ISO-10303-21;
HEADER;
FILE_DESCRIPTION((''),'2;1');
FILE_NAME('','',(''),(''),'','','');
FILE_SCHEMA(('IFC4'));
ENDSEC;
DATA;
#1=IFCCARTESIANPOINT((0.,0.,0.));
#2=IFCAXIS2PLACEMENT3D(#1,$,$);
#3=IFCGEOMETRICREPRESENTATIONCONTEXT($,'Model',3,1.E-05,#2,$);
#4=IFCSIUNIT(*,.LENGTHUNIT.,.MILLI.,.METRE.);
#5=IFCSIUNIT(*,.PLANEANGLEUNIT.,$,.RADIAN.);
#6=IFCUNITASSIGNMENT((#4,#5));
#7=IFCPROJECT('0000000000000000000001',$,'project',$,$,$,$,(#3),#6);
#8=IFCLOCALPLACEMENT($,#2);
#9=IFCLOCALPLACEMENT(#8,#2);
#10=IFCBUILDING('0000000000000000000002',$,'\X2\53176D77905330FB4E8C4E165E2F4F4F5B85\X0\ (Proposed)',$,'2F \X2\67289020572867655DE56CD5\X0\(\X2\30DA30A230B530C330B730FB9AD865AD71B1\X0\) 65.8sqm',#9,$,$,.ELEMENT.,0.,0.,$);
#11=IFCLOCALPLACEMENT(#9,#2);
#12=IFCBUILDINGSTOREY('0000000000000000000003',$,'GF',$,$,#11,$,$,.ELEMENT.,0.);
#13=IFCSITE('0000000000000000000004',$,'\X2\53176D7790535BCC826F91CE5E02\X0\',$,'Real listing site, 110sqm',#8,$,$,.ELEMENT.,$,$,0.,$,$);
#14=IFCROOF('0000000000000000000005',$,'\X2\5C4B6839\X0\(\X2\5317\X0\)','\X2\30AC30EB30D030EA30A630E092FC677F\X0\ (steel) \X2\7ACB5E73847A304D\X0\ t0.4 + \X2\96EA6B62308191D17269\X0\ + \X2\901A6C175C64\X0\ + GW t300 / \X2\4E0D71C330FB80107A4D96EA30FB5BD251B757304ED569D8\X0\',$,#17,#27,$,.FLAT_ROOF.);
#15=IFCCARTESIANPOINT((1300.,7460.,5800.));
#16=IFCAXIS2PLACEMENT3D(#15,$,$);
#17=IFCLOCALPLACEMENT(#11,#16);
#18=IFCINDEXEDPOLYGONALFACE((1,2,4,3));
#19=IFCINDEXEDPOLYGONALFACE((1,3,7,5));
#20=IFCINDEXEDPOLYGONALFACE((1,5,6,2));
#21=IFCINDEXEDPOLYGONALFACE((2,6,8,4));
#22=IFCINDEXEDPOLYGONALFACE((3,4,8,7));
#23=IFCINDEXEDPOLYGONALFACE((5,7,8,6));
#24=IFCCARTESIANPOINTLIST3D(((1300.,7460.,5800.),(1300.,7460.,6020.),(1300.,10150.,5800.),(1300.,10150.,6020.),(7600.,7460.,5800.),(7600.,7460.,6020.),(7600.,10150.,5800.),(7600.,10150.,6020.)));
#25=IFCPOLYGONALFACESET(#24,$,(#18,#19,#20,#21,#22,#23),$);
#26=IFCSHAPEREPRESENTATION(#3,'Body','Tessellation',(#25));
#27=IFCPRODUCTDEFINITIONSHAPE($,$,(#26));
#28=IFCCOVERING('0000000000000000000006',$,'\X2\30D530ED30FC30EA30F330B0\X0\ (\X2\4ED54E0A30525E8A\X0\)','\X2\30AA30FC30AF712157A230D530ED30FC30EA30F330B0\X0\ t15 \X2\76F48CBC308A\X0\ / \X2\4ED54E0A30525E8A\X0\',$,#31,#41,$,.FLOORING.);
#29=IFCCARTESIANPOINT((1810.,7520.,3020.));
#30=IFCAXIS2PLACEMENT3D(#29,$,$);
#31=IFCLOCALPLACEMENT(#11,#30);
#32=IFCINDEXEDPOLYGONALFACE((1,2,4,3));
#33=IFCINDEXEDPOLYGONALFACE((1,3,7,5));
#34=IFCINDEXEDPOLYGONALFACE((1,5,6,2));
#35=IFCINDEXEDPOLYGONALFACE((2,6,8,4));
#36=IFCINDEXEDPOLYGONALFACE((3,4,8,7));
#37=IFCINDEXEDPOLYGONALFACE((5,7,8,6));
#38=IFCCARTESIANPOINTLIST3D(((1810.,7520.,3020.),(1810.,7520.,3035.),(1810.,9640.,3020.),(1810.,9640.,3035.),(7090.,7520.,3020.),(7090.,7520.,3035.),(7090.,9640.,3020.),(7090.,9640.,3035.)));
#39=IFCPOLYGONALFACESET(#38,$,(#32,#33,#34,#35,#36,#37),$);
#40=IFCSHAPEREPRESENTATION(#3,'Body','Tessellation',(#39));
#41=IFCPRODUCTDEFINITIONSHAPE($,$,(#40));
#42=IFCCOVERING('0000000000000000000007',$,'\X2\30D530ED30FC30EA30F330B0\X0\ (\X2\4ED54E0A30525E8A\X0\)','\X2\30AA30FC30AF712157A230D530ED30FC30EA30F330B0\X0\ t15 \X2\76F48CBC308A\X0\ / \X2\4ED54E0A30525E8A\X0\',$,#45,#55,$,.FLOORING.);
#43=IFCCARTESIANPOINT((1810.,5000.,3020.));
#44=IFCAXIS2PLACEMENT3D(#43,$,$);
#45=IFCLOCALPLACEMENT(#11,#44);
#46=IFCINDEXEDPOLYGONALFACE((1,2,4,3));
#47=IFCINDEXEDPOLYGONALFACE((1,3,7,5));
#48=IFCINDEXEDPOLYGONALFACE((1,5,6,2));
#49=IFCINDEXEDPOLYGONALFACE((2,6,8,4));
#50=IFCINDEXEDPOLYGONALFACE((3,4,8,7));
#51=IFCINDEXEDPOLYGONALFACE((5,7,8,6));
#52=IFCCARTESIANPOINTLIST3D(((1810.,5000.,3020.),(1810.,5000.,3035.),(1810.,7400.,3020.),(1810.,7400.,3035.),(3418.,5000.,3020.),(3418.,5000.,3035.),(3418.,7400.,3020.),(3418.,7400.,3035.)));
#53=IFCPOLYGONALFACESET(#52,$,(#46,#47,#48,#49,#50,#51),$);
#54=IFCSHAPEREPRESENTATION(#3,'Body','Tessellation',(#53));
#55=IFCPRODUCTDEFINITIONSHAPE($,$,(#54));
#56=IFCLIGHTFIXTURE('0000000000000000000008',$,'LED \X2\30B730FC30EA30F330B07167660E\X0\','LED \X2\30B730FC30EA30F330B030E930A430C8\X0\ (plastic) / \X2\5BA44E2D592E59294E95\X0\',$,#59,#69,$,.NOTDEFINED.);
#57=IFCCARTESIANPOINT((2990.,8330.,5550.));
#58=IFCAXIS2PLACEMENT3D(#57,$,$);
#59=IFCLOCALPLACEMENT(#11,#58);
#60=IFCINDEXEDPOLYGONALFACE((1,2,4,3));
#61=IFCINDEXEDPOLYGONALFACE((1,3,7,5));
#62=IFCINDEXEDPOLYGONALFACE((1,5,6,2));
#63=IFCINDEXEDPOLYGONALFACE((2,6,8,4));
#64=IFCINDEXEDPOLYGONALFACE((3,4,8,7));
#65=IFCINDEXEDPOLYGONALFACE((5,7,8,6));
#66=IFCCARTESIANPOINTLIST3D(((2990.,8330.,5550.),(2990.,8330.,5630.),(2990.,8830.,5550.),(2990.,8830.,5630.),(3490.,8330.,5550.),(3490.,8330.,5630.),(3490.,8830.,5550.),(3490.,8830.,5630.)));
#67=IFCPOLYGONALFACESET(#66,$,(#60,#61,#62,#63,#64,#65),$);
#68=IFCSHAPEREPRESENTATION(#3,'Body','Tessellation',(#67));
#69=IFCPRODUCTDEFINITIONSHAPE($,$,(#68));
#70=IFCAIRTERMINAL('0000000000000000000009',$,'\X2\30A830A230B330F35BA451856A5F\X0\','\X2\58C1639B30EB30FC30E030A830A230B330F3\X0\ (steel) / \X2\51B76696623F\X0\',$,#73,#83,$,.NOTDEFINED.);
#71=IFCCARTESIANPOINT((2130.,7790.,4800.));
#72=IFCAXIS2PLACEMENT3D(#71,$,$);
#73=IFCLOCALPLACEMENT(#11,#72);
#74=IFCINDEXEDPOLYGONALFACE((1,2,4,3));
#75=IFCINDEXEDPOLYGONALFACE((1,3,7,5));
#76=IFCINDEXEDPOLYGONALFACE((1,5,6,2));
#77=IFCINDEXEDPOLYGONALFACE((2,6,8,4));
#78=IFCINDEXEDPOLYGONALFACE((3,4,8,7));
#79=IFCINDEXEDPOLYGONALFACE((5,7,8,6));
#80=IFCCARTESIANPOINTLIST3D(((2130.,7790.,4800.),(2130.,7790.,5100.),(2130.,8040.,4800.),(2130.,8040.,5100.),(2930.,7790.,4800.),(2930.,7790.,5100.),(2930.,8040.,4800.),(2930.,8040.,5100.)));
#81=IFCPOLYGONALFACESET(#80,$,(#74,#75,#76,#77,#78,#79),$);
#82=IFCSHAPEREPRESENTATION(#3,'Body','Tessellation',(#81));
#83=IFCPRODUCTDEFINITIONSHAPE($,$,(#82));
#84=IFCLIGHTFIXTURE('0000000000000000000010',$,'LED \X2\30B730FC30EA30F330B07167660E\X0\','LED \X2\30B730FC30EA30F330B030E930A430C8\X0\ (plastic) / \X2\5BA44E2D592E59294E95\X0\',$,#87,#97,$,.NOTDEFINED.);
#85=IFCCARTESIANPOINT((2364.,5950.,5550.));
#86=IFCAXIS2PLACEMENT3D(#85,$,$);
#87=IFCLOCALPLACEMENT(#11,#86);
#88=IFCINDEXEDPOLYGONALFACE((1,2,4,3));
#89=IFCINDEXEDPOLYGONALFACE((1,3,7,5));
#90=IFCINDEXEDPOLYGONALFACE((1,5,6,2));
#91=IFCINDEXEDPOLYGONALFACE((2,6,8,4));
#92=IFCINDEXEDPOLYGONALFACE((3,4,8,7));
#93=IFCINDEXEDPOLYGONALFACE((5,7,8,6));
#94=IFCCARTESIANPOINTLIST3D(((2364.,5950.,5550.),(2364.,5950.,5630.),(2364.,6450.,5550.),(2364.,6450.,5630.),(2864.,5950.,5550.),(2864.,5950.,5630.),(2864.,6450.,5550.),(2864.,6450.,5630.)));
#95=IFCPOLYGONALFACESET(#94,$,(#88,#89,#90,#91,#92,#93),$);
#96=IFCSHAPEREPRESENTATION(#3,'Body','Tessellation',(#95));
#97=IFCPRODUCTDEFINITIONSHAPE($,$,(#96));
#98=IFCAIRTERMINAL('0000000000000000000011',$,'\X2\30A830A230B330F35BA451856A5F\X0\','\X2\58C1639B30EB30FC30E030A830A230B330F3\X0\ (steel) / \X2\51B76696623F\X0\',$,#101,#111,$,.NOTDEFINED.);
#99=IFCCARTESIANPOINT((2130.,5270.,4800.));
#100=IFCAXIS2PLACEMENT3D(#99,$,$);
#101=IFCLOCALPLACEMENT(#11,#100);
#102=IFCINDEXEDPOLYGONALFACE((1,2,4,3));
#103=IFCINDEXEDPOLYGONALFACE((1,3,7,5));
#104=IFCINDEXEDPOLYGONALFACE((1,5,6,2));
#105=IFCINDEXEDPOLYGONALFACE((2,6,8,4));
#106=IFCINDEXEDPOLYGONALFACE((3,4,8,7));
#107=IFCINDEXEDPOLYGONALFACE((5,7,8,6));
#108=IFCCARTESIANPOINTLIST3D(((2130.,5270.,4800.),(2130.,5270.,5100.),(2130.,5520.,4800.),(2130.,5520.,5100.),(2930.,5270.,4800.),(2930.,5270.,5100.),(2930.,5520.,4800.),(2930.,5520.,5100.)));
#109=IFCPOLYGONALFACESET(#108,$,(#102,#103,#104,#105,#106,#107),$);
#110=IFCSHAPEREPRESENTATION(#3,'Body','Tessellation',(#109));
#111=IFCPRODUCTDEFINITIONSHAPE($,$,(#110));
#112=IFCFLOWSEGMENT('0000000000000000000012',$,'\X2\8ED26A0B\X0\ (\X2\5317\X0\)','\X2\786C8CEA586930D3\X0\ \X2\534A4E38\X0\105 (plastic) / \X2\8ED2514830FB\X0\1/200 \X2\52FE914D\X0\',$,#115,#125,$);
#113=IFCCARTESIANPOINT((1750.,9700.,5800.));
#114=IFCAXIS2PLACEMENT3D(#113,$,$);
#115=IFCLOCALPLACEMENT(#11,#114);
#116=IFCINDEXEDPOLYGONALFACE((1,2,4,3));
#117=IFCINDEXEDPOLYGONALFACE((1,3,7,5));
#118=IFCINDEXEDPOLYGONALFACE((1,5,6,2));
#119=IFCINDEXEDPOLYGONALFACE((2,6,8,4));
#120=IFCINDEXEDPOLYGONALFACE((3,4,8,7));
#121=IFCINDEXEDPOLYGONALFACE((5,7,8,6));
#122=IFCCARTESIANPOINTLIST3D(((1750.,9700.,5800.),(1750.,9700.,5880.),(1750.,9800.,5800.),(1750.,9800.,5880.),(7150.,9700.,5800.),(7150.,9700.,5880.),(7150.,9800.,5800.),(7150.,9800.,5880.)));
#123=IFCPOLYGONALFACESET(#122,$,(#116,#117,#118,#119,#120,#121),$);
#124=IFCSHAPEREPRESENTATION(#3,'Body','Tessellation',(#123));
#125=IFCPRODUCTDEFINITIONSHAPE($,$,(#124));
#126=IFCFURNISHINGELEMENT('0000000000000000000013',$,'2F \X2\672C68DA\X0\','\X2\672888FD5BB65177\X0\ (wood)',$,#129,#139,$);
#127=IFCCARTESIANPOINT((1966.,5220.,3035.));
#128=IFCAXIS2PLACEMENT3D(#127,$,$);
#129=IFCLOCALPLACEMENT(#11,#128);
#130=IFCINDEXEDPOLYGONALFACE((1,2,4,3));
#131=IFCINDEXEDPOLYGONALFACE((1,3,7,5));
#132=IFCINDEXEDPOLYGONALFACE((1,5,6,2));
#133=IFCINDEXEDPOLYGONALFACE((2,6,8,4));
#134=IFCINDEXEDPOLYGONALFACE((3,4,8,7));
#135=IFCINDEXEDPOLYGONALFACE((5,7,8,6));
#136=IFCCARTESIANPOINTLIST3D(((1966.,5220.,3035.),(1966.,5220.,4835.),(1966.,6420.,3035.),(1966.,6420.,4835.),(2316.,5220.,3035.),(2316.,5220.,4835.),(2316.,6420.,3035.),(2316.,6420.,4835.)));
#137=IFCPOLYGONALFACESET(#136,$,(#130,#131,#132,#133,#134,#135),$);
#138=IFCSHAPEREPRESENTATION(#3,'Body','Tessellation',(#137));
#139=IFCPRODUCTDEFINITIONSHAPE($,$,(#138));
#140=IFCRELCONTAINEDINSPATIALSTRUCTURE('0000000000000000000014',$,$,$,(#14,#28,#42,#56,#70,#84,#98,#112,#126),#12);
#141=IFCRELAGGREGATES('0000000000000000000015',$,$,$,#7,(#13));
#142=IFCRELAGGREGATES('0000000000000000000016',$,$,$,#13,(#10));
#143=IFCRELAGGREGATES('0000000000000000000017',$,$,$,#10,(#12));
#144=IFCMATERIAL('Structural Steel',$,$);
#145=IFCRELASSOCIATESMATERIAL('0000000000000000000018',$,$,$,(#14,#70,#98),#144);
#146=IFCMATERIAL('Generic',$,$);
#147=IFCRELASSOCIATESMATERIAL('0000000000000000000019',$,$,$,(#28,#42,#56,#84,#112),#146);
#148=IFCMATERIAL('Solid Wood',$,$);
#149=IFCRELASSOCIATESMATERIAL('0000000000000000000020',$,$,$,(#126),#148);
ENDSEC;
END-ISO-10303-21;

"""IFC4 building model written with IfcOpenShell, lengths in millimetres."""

from ifc_helpers import new_model, si_unit, frame, frame_2d, origin, place, context, project, spatial, rectangle, extrude, material, element, save


model = new_model("IFC4")

# Units and contexts
model_context = context("Model", 3, precision=1e-05, world=origin())
ifc_project = project(units=[si_unit("LENGTHUNIT", "METRE", prefix="MILLI"), si_unit("PLANEANGLEUNIT", "RADIAN")], contexts=[model_context])

# Site, building, storey
site_placement = place(None, origin())
site = spatial("IfcSite", under=ifc_project, at=site_placement, Name="北海道富良野市", ObjectType="Real listing site, 110sqm", CompositionType="ELEMENT", RefElevation=0.0)
building_placement = place(site_placement, origin())
building = spatial("IfcBuilding", under=site, at=building_placement, Name="北海道・二世帯住宅 (Proposed)", ObjectType="2F 木造在来工法(ペアサッシ・高断熱) 65.8sqm", CompositionType="ELEMENT", ElevationOfRefHeight=0.0, ElevationOfTerrain=0.0)
storey_placement = place(building_placement, origin())
storey = spatial("IfcBuildingStorey", under=building, at=storey_placement, Name="GF", CompositionType="ELEMENT", Elevation=0.0)

# Shared definitions
ifc_material_1 = material(Name="Solid Wood")

# Roof
ifc_material_2 = material(Name="Structural Steel")
for number, where, name in (
    (1, (1300.0, 7460.0, 5800.0), "屋根(北)"),
):
    element("IfcRoof", number, at=place(storey_placement, frame(where)), inside=storey, material=ifc_material_2, Name=name, Description="ガルバリウム鋼板 (steel) 立平葺き t0.4 + 雪止め金物 + 通気層 + GW t300 / 不燃・耐積雪・寒冷地仕様", PredefinedType="FLAT_ROOF", context=model_context, shape_type="SweptSolid", body=[
        extrude(rectangle(XDim=6300.0, YDim=2690.0, at=frame_2d((3150.0, 1345.0))), frame((1300.0, 7460.0, 5800.0)), (0.0, 0.0, 1.0), 220.0),
    ])

# Coverings
ifc_material_3 = material(Name="Generic")
covering_1_placement = place(storey_placement, frame((1810.0, 7520.0, 3020.0)))
element("IfcCovering", 2, at=covering_1_placement, inside=storey, material=ifc_material_3, Name="フローリング (仕上げ床)", Description="オーク無垢フローリング t15 直貼り / 仕上げ床", PredefinedType="FLOORING", context=model_context, shape_type="SweptSolid", body=[
    extrude(rectangle(XDim=5280.0, YDim=2120.0, at=frame_2d((2640.0, 1060.0))), frame((1810.0, 7520.0, 3020.0)), (0.0, 0.0, 1.0), 15.0),
])
covering_2_placement = place(storey_placement, frame((1810.0, 5000.0, 3020.0)))
element("IfcCovering", 3, at=covering_2_placement, inside=storey, material=ifc_material_3, Name="フローリング (仕上げ床)", Description="オーク無垢フローリング t15 直貼り / 仕上げ床", PredefinedType="FLOORING", context=model_context, shape_type="SweptSolid", body=[
    extrude(rectangle(XDim=1608.0, YDim=2400.0, at=frame_2d((804.0, 1200.0))), frame((1810.0, 5000.0, 3020.0)), (0.0, 0.0, 1.0), 15.0),
])

# Light fixture
light_fixture_1_placement = place(storey_placement, frame((2990.0, 8330.0, 5550.0)))
element("IfcLightFixture", 4, at=light_fixture_1_placement, inside=storey, material=ifc_material_3, Name="LED シーリング照明", Description="LED シーリングライト (plastic) / 室中央天井", PredefinedType="NOTDEFINED", context=model_context, shape_type="SweptSolid", body=[
    extrude(rectangle(XDim=500.0, YDim=500.0, at=frame_2d((250.0, 250.0))), frame((2990.0, 8330.0, 5550.0)), (0.0, 0.0, 1.0), 80.0),
])

# Air terminal
air_terminal_1_placement = place(storey_placement, frame((2130.0, 7790.0, 4800.0)))
element("IfcAirTerminal", 5, at=air_terminal_1_placement, inside=storey, material=ifc_material_2, Name="エアコン室内機", Description="壁掛ルームエアコン (steel) / 冷暖房", PredefinedType="NOTDEFINED", context=model_context, shape_type="SweptSolid", body=[
    extrude(rectangle(XDim=800.0, YDim=250.0, at=frame_2d((400.0, 125.0))), frame((2130.0, 7790.0, 4800.0)), (0.0, 0.0, 1.0), 300.0),
])

# Light fixture
light_fixture_2_placement = place(storey_placement, frame((2364.0, 5950.0, 5550.0)))
element("IfcLightFixture", 6, at=light_fixture_2_placement, inside=storey, material=ifc_material_3, Name="LED シーリング照明", Description="LED シーリングライト (plastic) / 室中央天井", PredefinedType="NOTDEFINED", context=model_context, shape_type="SweptSolid", body=[
    extrude(rectangle(XDim=500.0, YDim=500.0, at=frame_2d((250.0, 250.0))), frame((2364.0, 5950.0, 5550.0)), (0.0, 0.0, 1.0), 80.0),
])

# Air terminal
air_terminal_2_placement = place(storey_placement, frame((2130.0, 5270.0, 4800.0)))
element("IfcAirTerminal", 7, at=air_terminal_2_placement, inside=storey, material=ifc_material_2, Name="エアコン室内機", Description="壁掛ルームエアコン (steel) / 冷暖房", PredefinedType="NOTDEFINED", context=model_context, shape_type="SweptSolid", body=[
    extrude(rectangle(XDim=800.0, YDim=250.0, at=frame_2d((400.0, 125.0))), frame((2130.0, 5270.0, 4800.0)), (0.0, 0.0, 1.0), 300.0),
])

# Flow segment
flow_segment_placement = place(storey_placement, frame((1750.0, 9700.0, 5800.0)))
element("IfcFlowSegment", 8, at=flow_segment_placement, inside=storey, material=ifc_material_3, Name="軒樋 (北)", Description="硬質塩ビ 半丸105 (plastic) / 軒先・1/200 勾配", context=model_context, shape_type="SweptSolid", body=[
    extrude(rectangle(XDim=5400.0, YDim=100.0, at=frame_2d((2700.0, 50.0))), frame((1750.0, 9700.0, 5800.0)), (0.0, 0.0, 1.0), 80.0),
])

# Furnishing element
furnishing_placement = place(storey_placement, frame((1966.0, 5220.0, 3035.0)))
element("IfcFurnishingElement", 9, at=furnishing_placement, inside=storey, material=ifc_material_1, Name="2F 本棚", Description="木製家具 (wood)", context=model_context, shape_type="SweptSolid", body=[
    extrude(rectangle(XDim=350.0, YDim=1200.0, at=frame_2d((175.0, 600.0))), frame((1966.0, 5220.0, 3035.0)), (0.0, 0.0, 1.0), 1800.0),
])

save(model, "model.ifc")
